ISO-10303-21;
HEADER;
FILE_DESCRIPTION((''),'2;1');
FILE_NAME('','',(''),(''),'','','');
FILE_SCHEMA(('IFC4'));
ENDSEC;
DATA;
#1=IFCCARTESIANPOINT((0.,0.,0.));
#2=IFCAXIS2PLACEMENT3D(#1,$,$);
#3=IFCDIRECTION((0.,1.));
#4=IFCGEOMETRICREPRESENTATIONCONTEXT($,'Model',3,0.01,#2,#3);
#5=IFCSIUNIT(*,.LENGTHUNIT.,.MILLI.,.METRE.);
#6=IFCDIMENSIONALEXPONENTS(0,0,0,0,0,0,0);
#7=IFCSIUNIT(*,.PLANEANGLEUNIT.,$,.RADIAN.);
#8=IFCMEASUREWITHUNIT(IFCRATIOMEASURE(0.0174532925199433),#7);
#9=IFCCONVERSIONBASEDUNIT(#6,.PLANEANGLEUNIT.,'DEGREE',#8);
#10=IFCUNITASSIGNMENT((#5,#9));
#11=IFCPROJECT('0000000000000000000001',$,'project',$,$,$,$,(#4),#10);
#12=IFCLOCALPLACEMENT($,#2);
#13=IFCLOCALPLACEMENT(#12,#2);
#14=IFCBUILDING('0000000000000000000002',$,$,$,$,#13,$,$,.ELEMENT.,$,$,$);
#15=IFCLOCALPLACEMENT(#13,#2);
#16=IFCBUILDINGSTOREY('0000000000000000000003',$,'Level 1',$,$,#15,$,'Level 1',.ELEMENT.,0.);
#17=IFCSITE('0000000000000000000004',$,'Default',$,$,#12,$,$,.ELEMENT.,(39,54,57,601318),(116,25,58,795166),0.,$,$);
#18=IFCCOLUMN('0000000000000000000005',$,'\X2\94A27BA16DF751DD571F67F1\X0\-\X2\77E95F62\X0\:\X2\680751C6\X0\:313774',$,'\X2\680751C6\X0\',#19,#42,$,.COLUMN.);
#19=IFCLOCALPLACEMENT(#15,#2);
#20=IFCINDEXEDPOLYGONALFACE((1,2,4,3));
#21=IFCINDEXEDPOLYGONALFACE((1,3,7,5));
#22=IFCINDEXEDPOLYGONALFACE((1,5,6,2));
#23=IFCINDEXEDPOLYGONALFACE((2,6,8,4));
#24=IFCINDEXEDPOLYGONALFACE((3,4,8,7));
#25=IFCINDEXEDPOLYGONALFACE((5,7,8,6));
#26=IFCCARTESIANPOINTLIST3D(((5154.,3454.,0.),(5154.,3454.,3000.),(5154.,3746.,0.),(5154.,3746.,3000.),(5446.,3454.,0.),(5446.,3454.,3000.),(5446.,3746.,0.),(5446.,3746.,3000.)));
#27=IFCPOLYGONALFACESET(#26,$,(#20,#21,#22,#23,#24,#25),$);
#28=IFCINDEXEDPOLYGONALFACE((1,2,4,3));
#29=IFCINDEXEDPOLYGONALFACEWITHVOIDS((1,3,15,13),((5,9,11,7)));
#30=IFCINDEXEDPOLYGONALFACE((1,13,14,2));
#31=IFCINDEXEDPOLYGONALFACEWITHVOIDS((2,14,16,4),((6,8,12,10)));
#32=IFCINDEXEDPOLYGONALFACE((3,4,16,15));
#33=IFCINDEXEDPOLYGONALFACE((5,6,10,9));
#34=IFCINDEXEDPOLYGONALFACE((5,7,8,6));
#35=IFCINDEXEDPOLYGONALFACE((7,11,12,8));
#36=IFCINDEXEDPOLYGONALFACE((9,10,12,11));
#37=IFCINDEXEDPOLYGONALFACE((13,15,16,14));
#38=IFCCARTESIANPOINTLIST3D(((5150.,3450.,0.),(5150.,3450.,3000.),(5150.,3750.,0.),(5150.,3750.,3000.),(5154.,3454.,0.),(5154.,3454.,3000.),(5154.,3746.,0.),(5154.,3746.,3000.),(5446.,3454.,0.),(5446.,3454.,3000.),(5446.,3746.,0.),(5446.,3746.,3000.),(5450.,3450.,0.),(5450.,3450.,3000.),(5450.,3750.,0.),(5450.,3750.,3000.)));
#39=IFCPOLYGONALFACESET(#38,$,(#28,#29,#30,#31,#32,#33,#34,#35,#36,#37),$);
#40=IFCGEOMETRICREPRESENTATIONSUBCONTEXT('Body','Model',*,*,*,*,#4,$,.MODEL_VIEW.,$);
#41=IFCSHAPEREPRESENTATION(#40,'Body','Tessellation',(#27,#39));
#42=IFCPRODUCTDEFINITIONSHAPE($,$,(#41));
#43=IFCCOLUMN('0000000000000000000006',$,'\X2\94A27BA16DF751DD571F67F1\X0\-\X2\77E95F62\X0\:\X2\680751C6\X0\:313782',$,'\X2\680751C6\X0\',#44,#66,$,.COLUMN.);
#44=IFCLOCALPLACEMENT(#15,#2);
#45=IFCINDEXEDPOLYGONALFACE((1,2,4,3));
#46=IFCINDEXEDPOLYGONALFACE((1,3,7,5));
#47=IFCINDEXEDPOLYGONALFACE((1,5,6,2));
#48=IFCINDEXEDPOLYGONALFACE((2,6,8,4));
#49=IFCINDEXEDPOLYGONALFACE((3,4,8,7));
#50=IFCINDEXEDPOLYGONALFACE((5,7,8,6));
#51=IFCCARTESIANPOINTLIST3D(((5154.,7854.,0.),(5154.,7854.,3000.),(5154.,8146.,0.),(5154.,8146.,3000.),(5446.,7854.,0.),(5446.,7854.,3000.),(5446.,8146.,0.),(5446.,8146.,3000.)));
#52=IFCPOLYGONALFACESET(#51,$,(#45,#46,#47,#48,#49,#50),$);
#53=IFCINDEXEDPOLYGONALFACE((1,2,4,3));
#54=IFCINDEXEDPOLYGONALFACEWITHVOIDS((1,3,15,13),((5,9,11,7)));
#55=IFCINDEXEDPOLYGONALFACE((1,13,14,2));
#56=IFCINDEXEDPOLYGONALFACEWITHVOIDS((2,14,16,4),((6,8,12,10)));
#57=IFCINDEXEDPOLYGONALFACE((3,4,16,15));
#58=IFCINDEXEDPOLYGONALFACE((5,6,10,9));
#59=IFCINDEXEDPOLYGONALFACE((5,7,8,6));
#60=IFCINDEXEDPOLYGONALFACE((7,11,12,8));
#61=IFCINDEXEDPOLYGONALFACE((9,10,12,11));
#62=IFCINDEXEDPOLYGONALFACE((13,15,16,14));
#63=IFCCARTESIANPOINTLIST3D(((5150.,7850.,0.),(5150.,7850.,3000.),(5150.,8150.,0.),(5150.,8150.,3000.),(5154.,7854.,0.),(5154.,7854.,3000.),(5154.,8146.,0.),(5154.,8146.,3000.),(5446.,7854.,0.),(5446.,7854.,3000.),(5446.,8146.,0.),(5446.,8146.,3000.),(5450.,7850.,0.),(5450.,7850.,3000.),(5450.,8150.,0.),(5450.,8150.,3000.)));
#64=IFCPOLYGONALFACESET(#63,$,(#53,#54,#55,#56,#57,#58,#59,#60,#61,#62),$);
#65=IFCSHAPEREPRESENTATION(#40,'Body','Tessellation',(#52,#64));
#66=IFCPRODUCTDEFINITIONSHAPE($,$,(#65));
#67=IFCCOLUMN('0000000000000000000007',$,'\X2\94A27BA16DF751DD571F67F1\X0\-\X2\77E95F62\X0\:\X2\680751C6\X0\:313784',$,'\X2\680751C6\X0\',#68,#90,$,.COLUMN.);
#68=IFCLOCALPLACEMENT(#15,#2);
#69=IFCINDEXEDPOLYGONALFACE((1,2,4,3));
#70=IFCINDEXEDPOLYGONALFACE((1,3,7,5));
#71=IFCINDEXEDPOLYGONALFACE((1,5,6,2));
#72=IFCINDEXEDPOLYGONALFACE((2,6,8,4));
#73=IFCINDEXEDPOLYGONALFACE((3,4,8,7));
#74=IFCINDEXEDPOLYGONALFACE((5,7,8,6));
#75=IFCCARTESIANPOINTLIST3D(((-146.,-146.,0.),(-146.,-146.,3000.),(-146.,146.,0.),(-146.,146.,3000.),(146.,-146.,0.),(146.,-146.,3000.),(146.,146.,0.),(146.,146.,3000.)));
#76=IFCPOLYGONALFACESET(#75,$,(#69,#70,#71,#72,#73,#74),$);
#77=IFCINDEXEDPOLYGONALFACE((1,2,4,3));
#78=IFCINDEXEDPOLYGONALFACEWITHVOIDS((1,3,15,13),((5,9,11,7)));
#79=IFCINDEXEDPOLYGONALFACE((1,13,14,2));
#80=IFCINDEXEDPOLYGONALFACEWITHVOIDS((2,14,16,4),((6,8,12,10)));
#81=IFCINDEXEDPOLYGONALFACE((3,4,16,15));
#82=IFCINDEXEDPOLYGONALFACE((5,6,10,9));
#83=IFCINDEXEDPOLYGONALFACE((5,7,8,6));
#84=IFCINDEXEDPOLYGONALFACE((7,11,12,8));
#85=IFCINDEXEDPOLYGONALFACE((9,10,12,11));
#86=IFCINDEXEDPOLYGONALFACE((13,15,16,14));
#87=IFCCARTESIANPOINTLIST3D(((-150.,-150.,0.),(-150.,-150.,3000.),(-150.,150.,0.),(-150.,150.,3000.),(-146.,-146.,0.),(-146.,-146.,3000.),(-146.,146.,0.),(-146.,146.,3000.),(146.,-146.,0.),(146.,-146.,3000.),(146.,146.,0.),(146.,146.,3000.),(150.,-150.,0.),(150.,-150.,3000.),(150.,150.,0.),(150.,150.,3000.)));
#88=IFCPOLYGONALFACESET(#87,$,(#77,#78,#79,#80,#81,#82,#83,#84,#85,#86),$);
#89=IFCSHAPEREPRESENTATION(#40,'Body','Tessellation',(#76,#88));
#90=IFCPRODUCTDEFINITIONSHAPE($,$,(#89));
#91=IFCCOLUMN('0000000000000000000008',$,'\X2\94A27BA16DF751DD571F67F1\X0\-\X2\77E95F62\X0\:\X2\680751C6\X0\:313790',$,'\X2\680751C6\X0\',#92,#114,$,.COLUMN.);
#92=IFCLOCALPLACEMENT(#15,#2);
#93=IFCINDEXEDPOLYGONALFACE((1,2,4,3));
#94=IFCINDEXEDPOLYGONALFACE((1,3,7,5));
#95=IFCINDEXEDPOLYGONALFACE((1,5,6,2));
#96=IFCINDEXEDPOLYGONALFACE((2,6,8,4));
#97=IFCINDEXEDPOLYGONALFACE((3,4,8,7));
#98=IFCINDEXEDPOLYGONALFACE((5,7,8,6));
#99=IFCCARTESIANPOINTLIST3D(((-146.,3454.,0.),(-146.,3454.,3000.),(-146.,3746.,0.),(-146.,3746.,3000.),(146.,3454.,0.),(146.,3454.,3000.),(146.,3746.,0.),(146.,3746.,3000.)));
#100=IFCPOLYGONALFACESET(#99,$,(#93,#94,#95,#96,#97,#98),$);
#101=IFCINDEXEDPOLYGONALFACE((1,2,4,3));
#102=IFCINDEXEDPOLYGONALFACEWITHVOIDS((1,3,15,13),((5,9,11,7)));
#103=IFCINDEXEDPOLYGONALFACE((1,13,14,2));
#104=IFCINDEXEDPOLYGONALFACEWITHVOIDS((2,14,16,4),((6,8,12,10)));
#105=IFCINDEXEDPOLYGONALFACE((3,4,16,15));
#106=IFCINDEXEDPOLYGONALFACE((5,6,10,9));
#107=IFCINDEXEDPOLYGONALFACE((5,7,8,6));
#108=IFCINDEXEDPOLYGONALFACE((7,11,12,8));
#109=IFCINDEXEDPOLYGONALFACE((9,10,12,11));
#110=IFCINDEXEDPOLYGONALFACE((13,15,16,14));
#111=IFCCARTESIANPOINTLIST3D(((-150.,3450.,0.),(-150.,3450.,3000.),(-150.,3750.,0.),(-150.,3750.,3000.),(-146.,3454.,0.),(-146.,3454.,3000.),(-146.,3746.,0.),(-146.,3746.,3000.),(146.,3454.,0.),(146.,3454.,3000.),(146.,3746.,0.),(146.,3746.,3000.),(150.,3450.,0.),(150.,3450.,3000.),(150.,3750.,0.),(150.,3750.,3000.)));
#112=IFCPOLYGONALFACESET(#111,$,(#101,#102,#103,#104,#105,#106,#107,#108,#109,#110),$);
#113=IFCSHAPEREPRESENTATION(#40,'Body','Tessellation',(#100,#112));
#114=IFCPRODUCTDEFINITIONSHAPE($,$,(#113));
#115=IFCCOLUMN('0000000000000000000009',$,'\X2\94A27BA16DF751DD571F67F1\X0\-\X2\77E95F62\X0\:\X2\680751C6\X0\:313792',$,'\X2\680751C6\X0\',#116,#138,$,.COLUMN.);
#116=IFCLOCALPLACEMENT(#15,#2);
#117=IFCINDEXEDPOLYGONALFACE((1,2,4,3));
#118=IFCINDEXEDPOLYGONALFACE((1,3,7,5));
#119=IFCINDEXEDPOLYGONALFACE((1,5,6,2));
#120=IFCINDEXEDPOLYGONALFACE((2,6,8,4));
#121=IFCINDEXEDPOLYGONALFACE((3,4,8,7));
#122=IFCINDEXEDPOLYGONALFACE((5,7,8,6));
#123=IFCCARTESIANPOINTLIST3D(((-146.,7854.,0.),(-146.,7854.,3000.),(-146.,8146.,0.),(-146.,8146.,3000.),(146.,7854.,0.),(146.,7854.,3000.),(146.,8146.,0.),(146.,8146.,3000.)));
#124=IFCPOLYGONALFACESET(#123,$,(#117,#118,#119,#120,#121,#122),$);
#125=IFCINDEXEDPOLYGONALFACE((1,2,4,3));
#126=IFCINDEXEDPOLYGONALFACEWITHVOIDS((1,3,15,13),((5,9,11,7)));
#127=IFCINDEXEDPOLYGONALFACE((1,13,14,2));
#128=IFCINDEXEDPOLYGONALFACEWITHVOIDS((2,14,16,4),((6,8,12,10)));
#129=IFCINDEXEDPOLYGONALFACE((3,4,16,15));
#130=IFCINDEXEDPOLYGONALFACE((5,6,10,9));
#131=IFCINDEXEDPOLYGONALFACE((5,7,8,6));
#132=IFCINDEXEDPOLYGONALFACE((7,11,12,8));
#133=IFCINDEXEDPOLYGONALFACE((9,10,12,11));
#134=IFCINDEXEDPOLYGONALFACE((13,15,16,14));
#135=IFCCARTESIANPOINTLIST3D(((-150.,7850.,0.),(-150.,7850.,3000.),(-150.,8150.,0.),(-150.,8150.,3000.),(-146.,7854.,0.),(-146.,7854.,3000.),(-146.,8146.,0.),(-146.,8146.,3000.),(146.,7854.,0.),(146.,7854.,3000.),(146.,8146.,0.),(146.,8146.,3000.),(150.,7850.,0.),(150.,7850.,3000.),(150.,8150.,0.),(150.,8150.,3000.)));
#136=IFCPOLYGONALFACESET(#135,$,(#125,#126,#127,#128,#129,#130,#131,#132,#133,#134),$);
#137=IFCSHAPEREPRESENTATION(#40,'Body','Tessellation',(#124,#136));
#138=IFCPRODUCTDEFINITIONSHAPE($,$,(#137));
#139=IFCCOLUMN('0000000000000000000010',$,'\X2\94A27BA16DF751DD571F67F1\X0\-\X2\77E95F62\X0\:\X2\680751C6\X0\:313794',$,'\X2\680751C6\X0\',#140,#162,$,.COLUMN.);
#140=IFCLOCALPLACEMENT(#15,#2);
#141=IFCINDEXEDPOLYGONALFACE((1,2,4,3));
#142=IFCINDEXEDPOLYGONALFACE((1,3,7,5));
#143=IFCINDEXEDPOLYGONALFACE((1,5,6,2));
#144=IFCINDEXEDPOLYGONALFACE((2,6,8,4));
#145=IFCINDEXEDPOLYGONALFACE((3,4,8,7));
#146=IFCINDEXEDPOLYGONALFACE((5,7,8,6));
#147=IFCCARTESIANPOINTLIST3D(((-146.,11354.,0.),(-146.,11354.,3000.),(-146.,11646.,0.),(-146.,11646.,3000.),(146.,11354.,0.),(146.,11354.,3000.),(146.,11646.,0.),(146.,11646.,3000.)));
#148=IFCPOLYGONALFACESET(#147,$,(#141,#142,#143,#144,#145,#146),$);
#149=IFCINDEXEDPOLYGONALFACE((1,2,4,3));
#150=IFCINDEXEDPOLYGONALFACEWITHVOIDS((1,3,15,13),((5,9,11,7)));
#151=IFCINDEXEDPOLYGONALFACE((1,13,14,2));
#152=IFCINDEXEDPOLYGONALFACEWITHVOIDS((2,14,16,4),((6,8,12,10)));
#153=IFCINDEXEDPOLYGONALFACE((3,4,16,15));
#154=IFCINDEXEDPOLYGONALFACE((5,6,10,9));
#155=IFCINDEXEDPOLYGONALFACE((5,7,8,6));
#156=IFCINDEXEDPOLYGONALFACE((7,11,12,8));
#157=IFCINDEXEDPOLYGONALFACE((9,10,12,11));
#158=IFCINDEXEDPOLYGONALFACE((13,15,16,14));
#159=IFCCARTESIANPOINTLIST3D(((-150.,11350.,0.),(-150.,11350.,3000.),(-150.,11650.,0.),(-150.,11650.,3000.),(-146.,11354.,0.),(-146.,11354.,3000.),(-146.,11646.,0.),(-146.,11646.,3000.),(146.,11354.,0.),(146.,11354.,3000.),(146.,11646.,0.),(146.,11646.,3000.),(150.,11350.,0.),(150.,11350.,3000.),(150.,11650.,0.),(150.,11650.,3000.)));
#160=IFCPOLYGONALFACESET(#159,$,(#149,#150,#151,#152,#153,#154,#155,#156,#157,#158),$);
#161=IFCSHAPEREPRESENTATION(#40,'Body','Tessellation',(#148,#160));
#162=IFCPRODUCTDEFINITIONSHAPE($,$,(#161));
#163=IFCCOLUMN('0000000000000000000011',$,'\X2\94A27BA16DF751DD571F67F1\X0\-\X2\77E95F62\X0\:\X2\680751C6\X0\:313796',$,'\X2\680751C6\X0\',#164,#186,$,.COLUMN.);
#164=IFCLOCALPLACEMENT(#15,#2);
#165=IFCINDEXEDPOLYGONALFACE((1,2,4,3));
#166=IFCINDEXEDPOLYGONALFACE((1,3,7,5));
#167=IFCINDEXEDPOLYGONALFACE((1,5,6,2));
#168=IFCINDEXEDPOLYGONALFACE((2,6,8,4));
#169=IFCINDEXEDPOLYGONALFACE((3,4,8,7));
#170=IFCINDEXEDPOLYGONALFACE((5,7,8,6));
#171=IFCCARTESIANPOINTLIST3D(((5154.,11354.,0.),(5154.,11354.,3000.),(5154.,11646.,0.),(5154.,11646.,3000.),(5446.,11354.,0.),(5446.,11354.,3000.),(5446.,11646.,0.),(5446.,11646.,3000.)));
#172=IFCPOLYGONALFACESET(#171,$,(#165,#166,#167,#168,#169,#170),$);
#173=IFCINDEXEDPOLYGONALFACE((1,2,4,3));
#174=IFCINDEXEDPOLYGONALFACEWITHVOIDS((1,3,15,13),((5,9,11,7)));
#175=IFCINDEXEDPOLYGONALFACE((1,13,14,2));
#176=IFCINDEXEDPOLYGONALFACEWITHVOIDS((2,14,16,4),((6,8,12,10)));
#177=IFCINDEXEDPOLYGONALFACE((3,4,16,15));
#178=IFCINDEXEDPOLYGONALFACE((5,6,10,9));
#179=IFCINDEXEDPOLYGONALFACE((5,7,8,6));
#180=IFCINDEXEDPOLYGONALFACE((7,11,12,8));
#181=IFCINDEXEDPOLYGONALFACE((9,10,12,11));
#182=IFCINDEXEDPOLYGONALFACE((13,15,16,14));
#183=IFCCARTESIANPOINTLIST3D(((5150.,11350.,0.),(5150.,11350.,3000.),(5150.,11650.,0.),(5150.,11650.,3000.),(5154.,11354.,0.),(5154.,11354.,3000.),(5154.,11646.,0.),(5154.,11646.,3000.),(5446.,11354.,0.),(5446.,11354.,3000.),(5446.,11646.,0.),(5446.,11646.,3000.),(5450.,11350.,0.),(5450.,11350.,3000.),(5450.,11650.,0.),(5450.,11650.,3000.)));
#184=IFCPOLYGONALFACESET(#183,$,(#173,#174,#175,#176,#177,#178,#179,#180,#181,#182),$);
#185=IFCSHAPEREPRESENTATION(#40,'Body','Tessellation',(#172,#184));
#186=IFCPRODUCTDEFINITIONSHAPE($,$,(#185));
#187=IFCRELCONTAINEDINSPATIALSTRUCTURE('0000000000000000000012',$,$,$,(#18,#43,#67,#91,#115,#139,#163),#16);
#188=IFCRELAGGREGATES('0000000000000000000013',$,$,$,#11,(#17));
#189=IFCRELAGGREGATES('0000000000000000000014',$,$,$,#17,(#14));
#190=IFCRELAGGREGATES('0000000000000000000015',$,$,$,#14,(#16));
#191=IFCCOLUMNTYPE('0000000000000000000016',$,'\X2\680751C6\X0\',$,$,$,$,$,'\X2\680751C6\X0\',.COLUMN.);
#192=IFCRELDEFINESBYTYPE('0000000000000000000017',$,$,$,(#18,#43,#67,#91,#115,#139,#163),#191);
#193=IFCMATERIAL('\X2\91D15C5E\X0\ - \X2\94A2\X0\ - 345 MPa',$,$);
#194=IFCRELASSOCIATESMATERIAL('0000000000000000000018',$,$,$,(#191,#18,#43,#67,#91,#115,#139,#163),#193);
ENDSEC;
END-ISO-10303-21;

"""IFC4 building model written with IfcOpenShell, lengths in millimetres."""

from ifc_helpers import new_model, entity, si_unit, converted_unit, direction, frame, origin, origin_2d_with_axis, place, context, subcontext, project, spatial, polyline, rectangle, outline, extrude, source, transform, mapped, material, type_object, type_shapes, element, save


model = new_model("IFC4")

# Units and contexts
model_context_1 = context("Model", 3, precision=0.01, world=origin(), true_north=direction((0.0, 1.0)))
body_context_1 = subcontext(model_context_1, "Body", "Model", "MODEL_VIEW")
ifc_project = project(units=[si_unit("LENGTHUNIT", "METRE", prefix="MILLI"), converted_unit("PLANEANGLEUNIT", "DEGREE", entity("IfcRatioMeasure", 0.0174532925199433), si_unit("PLANEANGLEUNIT", "RADIAN"), dimensions=[0, 0, 0, 0, 0, 0, 0])], contexts=[model_context_1])

# Site, building, storey
site_placement = place(None, origin())
site = spatial("IfcSite", under=ifc_project, at=site_placement, Name="Default", CompositionType="ELEMENT", RefLatitude=(39, 54, 57, 601318), RefLongitude=(116, 25, 58, 795166), RefElevation=0.0)
building_placement = place(site_placement, origin())
building = spatial("IfcBuilding", under=site, at=building_placement, CompositionType="ELEMENT")
storey_placement = place(building_placement, origin())
storey = spatial("IfcBuildingStorey", under=building, at=storey_placement, Name="Level 1", LongName="Level 1", CompositionType="ELEMENT", Elevation=0.0)

# Columns
ifc_material_1 = material(Name="金属 - 钢 - 345 MPa")
column_type = type_object("IfcColumnType", Name="标准", ElementType="标准", PredefinedType="COLUMN", material=ifc_material_1)
shared_shape_1 = source(origin(), body_context_1, "Body", "SweptSolid", [
    extrude(rectangle(XDim=292.0, YDim=292.0, at=origin_2d_with_axis()), frame((0.0, 0.0, 0.0), z_axis=(0.0, 0.0, 1.0), x_axis=(-1.0, 0.0, 0.0)), (0.0, 0.0, 1.0), 3000.0),
    extrude(outline(polyline([(-150.0, -150.0), (150.0, -150.0), (150.0, 150.0), (-150.0, 150.0), (-150.0, -150.0)]), holes=[polyline([(-146.0, -146.0), (-146.0, 146.0), (146.0, 146.0), (146.0, -146.0), (-146.0, -146.0)])]), frame((0.0, 0.0, 0.0), z_axis=(0.0, 0.0, 1.0), x_axis=(-1.0, 0.0, 0.0)), (0.0, 0.0, 1.0), 3000.0),
])
type_shapes(column_type, [shared_shape_1])
for number, where, name in (
    (1, (5300.0, 3600.0, 0.0), "钢管混凝土柱-矩形:标准:313774"),
    (2, (5300.0, 8000.0, 0.0), "钢管混凝土柱-矩形:标准:313782"),
    (3, (0.0, 0.0, 0.0), "钢管混凝土柱-矩形:标准:313784"),
    (4, (0.0, 3600.0, 0.0), "钢管混凝土柱-矩形:标准:313790"),
    (5, (0.0, 8000.0, 0.0), "钢管混凝土柱-矩形:标准:313792"),
    (6, (0.0, 11500.0, 0.0), "钢管混凝土柱-矩形:标准:313794"),
    (7, (5300.0, 11500.0, 0.0), "钢管混凝土柱-矩形:标准:313796"),
):
    element("IfcColumn", number, at=place(storey_placement, frame(where)), inside=storey, type_object=column_type, material=ifc_material_1, Name=name, ObjectType="标准", PredefinedType="COLUMN", context=body_context_1, shape_type="MappedRepresentation", body=[
        mapped(shared_shape_1, transform((0.0, 0.0, 0.0), scale=1.0)),
    ])

save(model, "model.ifc")
